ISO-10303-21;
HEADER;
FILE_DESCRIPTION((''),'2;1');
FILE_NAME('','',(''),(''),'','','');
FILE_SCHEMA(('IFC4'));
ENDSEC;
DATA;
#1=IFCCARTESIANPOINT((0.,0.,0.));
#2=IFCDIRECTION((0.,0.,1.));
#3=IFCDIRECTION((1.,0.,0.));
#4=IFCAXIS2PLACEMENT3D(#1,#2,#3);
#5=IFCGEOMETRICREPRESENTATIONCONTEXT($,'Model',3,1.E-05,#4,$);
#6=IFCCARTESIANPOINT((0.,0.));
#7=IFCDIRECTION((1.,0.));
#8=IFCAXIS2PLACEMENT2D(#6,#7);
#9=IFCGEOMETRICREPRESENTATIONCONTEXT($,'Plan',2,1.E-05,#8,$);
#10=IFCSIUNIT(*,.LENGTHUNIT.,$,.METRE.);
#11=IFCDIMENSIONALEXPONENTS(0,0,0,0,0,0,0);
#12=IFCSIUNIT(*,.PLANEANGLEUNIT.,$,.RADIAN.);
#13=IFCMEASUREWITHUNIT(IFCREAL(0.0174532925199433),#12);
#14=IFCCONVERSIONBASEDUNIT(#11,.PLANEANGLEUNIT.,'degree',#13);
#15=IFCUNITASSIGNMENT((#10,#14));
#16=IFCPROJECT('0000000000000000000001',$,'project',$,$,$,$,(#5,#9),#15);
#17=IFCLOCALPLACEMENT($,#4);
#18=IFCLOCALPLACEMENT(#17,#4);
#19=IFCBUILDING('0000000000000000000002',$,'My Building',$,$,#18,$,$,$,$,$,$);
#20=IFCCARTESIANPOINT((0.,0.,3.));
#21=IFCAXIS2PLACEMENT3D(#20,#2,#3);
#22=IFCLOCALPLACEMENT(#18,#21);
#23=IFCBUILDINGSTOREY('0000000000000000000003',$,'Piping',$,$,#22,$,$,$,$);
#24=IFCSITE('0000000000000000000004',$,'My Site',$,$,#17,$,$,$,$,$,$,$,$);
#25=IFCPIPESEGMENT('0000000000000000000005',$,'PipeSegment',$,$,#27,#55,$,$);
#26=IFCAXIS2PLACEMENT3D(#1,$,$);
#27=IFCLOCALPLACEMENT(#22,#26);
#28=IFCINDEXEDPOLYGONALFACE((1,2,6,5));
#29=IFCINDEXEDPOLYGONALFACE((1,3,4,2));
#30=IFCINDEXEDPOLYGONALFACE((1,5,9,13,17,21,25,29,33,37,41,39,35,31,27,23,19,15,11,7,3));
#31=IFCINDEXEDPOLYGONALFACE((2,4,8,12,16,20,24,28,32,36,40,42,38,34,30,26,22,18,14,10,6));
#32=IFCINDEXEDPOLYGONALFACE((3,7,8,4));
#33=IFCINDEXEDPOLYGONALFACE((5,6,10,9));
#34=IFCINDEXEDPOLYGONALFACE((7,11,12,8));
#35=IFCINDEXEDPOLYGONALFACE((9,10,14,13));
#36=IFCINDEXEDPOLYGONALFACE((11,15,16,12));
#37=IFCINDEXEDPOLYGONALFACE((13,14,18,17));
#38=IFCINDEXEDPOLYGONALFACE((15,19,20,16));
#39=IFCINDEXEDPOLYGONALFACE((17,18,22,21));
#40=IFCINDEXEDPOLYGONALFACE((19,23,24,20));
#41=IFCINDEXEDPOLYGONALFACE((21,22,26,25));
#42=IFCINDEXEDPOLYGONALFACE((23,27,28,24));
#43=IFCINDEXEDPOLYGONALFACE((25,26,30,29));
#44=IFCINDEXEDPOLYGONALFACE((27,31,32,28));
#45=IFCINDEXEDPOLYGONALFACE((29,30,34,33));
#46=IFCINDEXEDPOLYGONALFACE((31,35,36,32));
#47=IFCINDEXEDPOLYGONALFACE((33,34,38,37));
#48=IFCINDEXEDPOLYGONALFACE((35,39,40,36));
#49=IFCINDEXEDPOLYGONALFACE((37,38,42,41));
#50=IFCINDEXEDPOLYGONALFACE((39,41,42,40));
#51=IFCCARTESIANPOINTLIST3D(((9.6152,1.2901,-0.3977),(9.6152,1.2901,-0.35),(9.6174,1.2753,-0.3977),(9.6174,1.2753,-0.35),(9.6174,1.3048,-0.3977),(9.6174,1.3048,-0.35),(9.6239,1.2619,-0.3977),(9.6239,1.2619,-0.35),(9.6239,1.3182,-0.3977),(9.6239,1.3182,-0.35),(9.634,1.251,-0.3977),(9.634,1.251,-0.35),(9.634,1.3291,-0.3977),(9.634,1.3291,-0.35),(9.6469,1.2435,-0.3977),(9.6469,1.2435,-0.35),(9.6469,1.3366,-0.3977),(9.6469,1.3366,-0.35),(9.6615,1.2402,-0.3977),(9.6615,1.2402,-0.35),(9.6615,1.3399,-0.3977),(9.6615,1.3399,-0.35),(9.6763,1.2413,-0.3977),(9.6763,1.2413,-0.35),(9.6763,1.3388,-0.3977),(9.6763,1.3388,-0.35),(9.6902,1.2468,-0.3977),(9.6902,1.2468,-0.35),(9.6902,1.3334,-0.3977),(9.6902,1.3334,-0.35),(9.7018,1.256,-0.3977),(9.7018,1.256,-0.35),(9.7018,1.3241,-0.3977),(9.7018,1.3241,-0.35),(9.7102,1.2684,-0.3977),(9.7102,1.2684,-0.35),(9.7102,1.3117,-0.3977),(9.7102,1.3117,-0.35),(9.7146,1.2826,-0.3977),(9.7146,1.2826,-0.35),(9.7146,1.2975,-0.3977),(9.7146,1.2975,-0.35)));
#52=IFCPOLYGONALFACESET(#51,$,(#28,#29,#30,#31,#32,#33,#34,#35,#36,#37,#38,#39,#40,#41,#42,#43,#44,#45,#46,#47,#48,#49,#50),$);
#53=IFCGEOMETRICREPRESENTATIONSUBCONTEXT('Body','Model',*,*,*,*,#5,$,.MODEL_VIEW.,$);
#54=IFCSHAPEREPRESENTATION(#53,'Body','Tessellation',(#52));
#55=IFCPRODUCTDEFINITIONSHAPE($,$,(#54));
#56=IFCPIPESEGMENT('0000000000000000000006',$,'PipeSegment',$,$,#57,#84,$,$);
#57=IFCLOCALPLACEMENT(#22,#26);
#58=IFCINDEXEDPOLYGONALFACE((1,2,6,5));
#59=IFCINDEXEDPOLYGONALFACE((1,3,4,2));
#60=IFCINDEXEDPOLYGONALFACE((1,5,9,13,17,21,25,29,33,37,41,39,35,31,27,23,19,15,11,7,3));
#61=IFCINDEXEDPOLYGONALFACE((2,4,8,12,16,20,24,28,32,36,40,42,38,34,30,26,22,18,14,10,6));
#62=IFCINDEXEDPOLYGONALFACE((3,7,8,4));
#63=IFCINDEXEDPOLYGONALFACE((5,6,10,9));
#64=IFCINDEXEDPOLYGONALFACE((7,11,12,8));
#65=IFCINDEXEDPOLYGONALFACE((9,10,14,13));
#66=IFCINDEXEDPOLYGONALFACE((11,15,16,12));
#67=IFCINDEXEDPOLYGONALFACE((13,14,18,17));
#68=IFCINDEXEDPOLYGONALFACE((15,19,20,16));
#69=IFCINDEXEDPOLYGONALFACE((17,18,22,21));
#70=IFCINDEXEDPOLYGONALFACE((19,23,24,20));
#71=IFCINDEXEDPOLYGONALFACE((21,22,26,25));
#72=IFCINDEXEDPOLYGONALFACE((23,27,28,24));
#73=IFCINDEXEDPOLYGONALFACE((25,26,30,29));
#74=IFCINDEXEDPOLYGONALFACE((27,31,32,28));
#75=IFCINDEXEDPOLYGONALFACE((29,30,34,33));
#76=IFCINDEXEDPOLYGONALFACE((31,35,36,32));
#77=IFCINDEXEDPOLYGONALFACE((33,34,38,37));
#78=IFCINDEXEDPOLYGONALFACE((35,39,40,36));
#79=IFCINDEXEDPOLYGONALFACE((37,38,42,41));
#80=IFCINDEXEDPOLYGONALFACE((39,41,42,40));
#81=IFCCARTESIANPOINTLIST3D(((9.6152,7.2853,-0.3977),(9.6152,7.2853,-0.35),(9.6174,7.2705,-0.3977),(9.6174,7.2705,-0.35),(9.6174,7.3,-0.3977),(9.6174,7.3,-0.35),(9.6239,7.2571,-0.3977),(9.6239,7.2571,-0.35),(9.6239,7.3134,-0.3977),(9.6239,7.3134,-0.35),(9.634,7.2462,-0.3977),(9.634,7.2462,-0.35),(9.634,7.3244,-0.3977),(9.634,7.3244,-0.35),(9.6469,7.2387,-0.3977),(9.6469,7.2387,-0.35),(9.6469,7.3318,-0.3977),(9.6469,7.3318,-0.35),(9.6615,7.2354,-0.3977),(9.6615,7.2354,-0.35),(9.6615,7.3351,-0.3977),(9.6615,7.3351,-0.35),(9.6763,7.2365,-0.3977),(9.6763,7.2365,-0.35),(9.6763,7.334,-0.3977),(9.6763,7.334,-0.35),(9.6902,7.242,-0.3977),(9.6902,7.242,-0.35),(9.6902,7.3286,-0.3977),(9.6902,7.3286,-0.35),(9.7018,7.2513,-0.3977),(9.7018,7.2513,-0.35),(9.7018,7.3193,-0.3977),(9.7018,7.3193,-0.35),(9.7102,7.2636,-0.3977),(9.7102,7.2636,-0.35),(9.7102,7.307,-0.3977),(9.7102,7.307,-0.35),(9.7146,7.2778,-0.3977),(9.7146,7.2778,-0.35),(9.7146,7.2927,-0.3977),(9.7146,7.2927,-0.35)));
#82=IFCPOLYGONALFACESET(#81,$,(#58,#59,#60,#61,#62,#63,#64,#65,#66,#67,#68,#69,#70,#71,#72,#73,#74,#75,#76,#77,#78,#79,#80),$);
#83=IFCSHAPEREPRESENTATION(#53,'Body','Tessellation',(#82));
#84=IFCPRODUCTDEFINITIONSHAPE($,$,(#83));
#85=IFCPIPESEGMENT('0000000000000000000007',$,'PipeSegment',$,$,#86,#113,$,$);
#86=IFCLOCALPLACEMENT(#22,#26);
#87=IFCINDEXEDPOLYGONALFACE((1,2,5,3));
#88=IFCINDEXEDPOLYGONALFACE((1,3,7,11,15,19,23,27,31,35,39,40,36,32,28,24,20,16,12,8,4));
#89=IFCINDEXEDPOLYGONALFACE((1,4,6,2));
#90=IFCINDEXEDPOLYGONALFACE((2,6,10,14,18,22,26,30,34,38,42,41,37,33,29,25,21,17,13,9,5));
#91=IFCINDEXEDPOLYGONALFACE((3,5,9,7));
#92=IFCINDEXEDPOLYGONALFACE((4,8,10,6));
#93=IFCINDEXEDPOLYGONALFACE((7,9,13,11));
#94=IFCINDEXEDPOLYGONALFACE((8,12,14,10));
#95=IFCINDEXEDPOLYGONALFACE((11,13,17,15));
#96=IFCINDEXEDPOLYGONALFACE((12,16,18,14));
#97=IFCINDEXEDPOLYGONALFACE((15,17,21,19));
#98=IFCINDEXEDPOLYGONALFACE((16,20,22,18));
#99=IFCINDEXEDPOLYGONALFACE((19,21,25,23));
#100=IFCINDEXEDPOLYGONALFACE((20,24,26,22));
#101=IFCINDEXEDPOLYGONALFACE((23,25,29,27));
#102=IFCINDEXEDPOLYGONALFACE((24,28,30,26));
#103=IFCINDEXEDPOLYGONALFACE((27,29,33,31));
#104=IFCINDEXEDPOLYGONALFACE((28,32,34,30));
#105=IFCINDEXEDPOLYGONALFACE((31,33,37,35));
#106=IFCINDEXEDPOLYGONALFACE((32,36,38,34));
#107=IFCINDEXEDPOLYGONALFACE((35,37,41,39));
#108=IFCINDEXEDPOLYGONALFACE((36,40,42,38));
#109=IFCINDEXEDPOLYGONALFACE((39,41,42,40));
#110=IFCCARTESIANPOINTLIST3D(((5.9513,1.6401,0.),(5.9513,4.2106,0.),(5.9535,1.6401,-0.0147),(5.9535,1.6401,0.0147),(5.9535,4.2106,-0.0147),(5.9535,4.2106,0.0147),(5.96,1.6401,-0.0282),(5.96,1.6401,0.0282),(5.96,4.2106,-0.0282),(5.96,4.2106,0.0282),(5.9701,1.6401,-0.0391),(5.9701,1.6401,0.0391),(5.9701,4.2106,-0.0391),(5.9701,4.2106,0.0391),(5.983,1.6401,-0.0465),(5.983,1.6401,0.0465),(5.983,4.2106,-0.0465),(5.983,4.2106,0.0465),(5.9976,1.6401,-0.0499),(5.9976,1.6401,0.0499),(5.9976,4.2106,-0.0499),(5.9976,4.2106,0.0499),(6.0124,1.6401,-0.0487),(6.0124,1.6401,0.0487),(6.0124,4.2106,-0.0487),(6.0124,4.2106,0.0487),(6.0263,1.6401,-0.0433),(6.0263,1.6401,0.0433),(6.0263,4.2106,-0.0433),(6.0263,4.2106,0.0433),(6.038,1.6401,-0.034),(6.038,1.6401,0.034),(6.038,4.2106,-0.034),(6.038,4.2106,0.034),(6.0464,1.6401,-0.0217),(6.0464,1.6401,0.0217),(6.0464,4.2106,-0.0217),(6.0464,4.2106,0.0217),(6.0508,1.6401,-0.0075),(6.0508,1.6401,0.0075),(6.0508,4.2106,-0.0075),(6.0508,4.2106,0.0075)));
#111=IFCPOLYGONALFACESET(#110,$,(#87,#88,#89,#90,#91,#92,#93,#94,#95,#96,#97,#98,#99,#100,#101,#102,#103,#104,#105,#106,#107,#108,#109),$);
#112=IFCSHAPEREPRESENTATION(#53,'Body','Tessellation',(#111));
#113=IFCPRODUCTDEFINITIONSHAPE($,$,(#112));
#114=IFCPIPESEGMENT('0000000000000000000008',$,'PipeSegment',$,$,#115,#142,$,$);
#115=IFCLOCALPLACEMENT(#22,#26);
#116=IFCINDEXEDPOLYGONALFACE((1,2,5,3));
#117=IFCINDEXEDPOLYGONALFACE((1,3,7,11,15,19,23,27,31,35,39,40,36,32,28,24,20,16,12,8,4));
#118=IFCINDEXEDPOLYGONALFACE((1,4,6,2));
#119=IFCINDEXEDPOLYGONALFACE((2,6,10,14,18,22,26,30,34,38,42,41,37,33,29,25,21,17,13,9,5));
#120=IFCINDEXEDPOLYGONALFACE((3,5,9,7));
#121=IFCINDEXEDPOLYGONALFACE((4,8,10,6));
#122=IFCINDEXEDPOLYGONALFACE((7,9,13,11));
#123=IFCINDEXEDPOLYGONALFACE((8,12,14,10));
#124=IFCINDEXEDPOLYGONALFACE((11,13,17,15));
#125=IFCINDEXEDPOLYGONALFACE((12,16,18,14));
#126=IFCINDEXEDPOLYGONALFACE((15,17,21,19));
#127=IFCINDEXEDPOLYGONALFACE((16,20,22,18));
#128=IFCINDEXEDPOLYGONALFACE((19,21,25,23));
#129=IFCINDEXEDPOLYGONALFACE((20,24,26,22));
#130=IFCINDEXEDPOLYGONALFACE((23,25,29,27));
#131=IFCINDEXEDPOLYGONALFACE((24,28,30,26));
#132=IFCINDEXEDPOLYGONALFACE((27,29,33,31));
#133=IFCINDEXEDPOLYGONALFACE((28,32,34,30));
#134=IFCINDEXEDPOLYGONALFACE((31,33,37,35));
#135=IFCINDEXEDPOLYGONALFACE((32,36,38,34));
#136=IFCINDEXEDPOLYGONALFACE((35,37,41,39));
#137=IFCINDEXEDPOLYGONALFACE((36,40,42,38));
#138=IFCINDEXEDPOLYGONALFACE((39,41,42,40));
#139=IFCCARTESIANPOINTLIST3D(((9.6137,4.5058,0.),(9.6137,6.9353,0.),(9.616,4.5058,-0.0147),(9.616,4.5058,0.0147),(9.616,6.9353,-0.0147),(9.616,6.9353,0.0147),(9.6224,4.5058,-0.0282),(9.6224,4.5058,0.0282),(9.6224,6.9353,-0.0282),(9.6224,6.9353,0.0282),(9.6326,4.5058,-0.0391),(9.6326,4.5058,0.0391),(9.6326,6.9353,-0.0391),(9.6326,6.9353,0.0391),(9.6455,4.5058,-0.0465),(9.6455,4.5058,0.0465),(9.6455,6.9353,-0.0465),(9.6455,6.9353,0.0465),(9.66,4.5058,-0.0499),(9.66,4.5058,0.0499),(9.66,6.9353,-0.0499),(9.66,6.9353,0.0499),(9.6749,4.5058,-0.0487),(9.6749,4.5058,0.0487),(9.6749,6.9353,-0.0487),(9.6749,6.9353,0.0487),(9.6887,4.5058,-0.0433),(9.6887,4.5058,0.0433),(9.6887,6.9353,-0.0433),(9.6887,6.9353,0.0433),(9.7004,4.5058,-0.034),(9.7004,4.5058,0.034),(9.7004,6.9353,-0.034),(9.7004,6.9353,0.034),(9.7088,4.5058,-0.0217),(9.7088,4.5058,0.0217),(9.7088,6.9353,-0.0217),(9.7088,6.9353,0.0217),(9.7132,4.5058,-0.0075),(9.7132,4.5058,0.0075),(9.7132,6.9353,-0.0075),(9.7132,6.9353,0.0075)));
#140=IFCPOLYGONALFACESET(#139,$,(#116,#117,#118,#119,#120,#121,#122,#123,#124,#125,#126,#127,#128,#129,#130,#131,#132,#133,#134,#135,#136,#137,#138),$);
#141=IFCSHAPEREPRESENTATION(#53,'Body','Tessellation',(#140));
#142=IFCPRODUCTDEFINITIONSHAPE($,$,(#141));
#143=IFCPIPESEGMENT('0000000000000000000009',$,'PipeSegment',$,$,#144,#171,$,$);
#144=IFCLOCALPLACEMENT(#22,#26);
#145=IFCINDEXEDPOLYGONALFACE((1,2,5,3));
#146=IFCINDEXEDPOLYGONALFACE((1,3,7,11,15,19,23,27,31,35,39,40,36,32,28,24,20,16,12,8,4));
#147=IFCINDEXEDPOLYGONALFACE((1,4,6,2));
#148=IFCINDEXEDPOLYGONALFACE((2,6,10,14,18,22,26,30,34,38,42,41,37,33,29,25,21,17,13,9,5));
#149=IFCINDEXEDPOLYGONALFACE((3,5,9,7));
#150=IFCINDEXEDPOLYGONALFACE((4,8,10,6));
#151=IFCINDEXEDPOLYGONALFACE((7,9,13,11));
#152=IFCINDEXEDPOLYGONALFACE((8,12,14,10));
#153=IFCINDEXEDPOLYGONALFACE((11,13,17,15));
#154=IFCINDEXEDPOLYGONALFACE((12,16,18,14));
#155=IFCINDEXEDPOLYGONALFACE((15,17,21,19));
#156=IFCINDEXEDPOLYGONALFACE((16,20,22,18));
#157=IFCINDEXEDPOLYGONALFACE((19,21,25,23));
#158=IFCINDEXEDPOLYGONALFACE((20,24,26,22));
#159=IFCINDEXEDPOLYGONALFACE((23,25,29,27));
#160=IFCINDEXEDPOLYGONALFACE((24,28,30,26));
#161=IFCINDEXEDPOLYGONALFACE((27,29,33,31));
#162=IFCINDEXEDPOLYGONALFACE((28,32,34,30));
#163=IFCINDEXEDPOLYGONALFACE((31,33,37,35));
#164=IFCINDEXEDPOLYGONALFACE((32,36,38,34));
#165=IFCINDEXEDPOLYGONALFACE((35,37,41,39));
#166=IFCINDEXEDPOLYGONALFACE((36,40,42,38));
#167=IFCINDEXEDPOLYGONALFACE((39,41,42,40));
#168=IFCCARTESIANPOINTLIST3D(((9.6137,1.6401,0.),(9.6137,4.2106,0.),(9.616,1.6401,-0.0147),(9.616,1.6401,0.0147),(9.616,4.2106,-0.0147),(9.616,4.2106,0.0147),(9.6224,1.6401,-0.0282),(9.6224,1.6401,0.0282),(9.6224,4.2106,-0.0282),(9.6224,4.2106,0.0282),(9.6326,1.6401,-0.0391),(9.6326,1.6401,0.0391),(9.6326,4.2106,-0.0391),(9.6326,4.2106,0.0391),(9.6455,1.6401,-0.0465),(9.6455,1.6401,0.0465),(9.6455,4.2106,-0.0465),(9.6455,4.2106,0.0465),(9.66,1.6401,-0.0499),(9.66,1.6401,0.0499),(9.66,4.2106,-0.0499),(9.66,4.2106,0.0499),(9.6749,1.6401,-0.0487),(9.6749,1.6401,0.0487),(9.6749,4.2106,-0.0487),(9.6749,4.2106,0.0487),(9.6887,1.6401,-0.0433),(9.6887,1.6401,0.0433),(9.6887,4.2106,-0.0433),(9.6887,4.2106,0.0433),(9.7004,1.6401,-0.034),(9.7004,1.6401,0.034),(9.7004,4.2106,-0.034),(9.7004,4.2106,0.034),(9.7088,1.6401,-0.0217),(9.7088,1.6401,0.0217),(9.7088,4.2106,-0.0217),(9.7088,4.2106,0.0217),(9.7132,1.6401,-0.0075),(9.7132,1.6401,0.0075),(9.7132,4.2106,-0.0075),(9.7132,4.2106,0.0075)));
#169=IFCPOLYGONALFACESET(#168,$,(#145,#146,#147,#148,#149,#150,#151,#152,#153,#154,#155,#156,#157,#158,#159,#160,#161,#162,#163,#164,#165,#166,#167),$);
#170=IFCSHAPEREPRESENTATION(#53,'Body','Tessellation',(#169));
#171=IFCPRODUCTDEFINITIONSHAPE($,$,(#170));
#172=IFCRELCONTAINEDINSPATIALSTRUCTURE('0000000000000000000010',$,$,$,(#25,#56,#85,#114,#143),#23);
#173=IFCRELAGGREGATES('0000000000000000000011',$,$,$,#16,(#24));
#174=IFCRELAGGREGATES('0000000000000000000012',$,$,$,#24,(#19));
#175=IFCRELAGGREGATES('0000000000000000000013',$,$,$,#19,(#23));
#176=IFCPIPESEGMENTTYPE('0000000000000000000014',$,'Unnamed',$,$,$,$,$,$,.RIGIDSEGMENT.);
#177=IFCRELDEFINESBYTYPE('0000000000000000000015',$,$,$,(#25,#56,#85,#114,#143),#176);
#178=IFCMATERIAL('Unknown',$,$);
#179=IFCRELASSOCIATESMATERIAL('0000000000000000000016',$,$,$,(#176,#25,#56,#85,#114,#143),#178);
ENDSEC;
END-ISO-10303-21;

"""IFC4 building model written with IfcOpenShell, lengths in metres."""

from ifc_helpers import new_model, entity, si_unit, converted_unit, frame, origin_with_axes, origin_2d_with_axis, place, context, subcontext, project, spatial, circle, extrude, material, material_profile, profile_set, profile_usage, type_object, element, save


model = new_model("IFC4")

# Units and contexts
model_context = context("Model", 3, precision=1e-05, world=origin_with_axes())
plan_context = context("Plan", 2, precision=1e-05, world=origin_2d_with_axis())
body_context = subcontext(model_context, "Body", "Model", "MODEL_VIEW")
ifc_project = project(units=[si_unit("LENGTHUNIT", "METRE"), converted_unit("PLANEANGLEUNIT", "degree", entity("IfcReal", 0.0174532925199433), si_unit("PLANEANGLEUNIT", "RADIAN"), dimensions=[0, 0, 0, 0, 0, 0, 0])], contexts=[model_context, plan_context])

# Site, building, storey
site_placement = place(None, origin_with_axes())
site = spatial("IfcSite", under=ifc_project, at=site_placement, Name="My Site")
building_placement = place(site_placement, origin_with_axes())
building = spatial("IfcBuilding", under=site, at=building_placement, Name="My Building")
storey_placement = place(building_placement, frame((0.0, 0.0, 3.0), z_axis=(0.0, 0.0, 1.0), x_axis=(1.0, 0.0, 0.0)))
storey = spatial("IfcBuildingStorey", under=building, at=storey_placement, Name="Piping")

# Pipe segments
ifc_material = material(Name="Unknown")
ifc_material_profile_1 = material_profile(ifc_material, circle(Radius=0.05))
ifc_profile_set_1 = profile_set([ifc_material_profile_1])
pipe_segment_type = type_object("IfcPipeSegmentType", Name="Unnamed", PredefinedType="RIGIDSEGMENT", material=ifc_profile_set_1)
ifc_profile_usage_1 = profile_usage(ifc_profile_set_1, cardinal=5)
pipe_segment_1_placement = place(storey_placement, frame((9.6652, 1.2901, -0.35), z_axis=(0.0, 0.0, -1.0), x_axis=(-1.0, 0.0, 0.0)))
element("IfcPipeSegment", 1, at=pipe_segment_1_placement, inside=storey, type_object=pipe_segment_type, material=ifc_profile_usage_1, Name="PipeSegment", context=body_context, shape_type="SweptSolid", body=[
    extrude(circle(Radius=0.05), origin_with_axes(), (0.0, 0.0, 1.0), 0.0477),
])
ifc_profile_usage_2 = profile_usage(ifc_profile_set_1, cardinal=5)
pipe_segment_2_placement = place(storey_placement, frame((9.6652, 7.2853, -0.35), z_axis=(0.0, 0.0, -1.0), x_axis=(-1.0, 0.0, 0.0)))
element("IfcPipeSegment", 2, at=pipe_segment_2_placement, inside=storey, type_object=pipe_segment_type, material=ifc_profile_usage_2, Name="PipeSegment", context=body_context, shape_type="SweptSolid", body=[
    extrude(circle(Radius=0.05), origin_with_axes(), (0.0, 0.0, 1.0), 0.0477),
])
ifc_profile_usage_3 = profile_usage(ifc_profile_set_1, cardinal=5)
pipe_segment_3_placement = place(storey_placement, frame((6.0013, 4.2106, 0.0), z_axis=(0.0, -1.0, 0.0), x_axis=(-1.0, 0.0, 0.0)))
element("IfcPipeSegment", 3, at=pipe_segment_3_placement, inside=storey, type_object=pipe_segment_type, material=ifc_profile_usage_3, Name="PipeSegment", context=body_context, shape_type="SweptSolid", body=[
    extrude(circle(Radius=0.05), origin_with_axes(), (0.0, 0.0, 1.0), 2.5705),
])
ifc_profile_usage_4 = profile_usage(ifc_profile_set_1, cardinal=5)
pipe_segment_4_placement = place(storey_placement, frame((9.6637, 6.9353, 0.0), z_axis=(0.0, -1.0, 0.0), x_axis=(-1.0, 0.0, 0.0)))
element("IfcPipeSegment", 4, at=pipe_segment_4_placement, inside=storey, type_object=pipe_segment_type, material=ifc_profile_usage_4, Name="PipeSegment", context=body_context, shape_type="SweptSolid", body=[
    extrude(circle(Radius=0.05), origin_with_axes(), (0.0, 0.0, 1.0), 2.4294),
])
ifc_profile_usage_5 = profile_usage(ifc_profile_set_1, cardinal=5)
pipe_segment_5_placement = place(storey_placement, frame((9.6637, 4.2106, 0.0), z_axis=(0.0, -1.0, 0.0), x_axis=(-1.0, 0.0, 0.0)))
element("IfcPipeSegment", 5, at=pipe_segment_5_placement, inside=storey, type_object=pipe_segment_type, material=ifc_profile_usage_5, Name="PipeSegment", context=body_context, shape_type="SweptSolid", body=[
    extrude(circle(Radius=0.05), origin_with_axes(), (0.0, 0.0, 1.0), 2.5705),
])

save(model, "model.ifc")
